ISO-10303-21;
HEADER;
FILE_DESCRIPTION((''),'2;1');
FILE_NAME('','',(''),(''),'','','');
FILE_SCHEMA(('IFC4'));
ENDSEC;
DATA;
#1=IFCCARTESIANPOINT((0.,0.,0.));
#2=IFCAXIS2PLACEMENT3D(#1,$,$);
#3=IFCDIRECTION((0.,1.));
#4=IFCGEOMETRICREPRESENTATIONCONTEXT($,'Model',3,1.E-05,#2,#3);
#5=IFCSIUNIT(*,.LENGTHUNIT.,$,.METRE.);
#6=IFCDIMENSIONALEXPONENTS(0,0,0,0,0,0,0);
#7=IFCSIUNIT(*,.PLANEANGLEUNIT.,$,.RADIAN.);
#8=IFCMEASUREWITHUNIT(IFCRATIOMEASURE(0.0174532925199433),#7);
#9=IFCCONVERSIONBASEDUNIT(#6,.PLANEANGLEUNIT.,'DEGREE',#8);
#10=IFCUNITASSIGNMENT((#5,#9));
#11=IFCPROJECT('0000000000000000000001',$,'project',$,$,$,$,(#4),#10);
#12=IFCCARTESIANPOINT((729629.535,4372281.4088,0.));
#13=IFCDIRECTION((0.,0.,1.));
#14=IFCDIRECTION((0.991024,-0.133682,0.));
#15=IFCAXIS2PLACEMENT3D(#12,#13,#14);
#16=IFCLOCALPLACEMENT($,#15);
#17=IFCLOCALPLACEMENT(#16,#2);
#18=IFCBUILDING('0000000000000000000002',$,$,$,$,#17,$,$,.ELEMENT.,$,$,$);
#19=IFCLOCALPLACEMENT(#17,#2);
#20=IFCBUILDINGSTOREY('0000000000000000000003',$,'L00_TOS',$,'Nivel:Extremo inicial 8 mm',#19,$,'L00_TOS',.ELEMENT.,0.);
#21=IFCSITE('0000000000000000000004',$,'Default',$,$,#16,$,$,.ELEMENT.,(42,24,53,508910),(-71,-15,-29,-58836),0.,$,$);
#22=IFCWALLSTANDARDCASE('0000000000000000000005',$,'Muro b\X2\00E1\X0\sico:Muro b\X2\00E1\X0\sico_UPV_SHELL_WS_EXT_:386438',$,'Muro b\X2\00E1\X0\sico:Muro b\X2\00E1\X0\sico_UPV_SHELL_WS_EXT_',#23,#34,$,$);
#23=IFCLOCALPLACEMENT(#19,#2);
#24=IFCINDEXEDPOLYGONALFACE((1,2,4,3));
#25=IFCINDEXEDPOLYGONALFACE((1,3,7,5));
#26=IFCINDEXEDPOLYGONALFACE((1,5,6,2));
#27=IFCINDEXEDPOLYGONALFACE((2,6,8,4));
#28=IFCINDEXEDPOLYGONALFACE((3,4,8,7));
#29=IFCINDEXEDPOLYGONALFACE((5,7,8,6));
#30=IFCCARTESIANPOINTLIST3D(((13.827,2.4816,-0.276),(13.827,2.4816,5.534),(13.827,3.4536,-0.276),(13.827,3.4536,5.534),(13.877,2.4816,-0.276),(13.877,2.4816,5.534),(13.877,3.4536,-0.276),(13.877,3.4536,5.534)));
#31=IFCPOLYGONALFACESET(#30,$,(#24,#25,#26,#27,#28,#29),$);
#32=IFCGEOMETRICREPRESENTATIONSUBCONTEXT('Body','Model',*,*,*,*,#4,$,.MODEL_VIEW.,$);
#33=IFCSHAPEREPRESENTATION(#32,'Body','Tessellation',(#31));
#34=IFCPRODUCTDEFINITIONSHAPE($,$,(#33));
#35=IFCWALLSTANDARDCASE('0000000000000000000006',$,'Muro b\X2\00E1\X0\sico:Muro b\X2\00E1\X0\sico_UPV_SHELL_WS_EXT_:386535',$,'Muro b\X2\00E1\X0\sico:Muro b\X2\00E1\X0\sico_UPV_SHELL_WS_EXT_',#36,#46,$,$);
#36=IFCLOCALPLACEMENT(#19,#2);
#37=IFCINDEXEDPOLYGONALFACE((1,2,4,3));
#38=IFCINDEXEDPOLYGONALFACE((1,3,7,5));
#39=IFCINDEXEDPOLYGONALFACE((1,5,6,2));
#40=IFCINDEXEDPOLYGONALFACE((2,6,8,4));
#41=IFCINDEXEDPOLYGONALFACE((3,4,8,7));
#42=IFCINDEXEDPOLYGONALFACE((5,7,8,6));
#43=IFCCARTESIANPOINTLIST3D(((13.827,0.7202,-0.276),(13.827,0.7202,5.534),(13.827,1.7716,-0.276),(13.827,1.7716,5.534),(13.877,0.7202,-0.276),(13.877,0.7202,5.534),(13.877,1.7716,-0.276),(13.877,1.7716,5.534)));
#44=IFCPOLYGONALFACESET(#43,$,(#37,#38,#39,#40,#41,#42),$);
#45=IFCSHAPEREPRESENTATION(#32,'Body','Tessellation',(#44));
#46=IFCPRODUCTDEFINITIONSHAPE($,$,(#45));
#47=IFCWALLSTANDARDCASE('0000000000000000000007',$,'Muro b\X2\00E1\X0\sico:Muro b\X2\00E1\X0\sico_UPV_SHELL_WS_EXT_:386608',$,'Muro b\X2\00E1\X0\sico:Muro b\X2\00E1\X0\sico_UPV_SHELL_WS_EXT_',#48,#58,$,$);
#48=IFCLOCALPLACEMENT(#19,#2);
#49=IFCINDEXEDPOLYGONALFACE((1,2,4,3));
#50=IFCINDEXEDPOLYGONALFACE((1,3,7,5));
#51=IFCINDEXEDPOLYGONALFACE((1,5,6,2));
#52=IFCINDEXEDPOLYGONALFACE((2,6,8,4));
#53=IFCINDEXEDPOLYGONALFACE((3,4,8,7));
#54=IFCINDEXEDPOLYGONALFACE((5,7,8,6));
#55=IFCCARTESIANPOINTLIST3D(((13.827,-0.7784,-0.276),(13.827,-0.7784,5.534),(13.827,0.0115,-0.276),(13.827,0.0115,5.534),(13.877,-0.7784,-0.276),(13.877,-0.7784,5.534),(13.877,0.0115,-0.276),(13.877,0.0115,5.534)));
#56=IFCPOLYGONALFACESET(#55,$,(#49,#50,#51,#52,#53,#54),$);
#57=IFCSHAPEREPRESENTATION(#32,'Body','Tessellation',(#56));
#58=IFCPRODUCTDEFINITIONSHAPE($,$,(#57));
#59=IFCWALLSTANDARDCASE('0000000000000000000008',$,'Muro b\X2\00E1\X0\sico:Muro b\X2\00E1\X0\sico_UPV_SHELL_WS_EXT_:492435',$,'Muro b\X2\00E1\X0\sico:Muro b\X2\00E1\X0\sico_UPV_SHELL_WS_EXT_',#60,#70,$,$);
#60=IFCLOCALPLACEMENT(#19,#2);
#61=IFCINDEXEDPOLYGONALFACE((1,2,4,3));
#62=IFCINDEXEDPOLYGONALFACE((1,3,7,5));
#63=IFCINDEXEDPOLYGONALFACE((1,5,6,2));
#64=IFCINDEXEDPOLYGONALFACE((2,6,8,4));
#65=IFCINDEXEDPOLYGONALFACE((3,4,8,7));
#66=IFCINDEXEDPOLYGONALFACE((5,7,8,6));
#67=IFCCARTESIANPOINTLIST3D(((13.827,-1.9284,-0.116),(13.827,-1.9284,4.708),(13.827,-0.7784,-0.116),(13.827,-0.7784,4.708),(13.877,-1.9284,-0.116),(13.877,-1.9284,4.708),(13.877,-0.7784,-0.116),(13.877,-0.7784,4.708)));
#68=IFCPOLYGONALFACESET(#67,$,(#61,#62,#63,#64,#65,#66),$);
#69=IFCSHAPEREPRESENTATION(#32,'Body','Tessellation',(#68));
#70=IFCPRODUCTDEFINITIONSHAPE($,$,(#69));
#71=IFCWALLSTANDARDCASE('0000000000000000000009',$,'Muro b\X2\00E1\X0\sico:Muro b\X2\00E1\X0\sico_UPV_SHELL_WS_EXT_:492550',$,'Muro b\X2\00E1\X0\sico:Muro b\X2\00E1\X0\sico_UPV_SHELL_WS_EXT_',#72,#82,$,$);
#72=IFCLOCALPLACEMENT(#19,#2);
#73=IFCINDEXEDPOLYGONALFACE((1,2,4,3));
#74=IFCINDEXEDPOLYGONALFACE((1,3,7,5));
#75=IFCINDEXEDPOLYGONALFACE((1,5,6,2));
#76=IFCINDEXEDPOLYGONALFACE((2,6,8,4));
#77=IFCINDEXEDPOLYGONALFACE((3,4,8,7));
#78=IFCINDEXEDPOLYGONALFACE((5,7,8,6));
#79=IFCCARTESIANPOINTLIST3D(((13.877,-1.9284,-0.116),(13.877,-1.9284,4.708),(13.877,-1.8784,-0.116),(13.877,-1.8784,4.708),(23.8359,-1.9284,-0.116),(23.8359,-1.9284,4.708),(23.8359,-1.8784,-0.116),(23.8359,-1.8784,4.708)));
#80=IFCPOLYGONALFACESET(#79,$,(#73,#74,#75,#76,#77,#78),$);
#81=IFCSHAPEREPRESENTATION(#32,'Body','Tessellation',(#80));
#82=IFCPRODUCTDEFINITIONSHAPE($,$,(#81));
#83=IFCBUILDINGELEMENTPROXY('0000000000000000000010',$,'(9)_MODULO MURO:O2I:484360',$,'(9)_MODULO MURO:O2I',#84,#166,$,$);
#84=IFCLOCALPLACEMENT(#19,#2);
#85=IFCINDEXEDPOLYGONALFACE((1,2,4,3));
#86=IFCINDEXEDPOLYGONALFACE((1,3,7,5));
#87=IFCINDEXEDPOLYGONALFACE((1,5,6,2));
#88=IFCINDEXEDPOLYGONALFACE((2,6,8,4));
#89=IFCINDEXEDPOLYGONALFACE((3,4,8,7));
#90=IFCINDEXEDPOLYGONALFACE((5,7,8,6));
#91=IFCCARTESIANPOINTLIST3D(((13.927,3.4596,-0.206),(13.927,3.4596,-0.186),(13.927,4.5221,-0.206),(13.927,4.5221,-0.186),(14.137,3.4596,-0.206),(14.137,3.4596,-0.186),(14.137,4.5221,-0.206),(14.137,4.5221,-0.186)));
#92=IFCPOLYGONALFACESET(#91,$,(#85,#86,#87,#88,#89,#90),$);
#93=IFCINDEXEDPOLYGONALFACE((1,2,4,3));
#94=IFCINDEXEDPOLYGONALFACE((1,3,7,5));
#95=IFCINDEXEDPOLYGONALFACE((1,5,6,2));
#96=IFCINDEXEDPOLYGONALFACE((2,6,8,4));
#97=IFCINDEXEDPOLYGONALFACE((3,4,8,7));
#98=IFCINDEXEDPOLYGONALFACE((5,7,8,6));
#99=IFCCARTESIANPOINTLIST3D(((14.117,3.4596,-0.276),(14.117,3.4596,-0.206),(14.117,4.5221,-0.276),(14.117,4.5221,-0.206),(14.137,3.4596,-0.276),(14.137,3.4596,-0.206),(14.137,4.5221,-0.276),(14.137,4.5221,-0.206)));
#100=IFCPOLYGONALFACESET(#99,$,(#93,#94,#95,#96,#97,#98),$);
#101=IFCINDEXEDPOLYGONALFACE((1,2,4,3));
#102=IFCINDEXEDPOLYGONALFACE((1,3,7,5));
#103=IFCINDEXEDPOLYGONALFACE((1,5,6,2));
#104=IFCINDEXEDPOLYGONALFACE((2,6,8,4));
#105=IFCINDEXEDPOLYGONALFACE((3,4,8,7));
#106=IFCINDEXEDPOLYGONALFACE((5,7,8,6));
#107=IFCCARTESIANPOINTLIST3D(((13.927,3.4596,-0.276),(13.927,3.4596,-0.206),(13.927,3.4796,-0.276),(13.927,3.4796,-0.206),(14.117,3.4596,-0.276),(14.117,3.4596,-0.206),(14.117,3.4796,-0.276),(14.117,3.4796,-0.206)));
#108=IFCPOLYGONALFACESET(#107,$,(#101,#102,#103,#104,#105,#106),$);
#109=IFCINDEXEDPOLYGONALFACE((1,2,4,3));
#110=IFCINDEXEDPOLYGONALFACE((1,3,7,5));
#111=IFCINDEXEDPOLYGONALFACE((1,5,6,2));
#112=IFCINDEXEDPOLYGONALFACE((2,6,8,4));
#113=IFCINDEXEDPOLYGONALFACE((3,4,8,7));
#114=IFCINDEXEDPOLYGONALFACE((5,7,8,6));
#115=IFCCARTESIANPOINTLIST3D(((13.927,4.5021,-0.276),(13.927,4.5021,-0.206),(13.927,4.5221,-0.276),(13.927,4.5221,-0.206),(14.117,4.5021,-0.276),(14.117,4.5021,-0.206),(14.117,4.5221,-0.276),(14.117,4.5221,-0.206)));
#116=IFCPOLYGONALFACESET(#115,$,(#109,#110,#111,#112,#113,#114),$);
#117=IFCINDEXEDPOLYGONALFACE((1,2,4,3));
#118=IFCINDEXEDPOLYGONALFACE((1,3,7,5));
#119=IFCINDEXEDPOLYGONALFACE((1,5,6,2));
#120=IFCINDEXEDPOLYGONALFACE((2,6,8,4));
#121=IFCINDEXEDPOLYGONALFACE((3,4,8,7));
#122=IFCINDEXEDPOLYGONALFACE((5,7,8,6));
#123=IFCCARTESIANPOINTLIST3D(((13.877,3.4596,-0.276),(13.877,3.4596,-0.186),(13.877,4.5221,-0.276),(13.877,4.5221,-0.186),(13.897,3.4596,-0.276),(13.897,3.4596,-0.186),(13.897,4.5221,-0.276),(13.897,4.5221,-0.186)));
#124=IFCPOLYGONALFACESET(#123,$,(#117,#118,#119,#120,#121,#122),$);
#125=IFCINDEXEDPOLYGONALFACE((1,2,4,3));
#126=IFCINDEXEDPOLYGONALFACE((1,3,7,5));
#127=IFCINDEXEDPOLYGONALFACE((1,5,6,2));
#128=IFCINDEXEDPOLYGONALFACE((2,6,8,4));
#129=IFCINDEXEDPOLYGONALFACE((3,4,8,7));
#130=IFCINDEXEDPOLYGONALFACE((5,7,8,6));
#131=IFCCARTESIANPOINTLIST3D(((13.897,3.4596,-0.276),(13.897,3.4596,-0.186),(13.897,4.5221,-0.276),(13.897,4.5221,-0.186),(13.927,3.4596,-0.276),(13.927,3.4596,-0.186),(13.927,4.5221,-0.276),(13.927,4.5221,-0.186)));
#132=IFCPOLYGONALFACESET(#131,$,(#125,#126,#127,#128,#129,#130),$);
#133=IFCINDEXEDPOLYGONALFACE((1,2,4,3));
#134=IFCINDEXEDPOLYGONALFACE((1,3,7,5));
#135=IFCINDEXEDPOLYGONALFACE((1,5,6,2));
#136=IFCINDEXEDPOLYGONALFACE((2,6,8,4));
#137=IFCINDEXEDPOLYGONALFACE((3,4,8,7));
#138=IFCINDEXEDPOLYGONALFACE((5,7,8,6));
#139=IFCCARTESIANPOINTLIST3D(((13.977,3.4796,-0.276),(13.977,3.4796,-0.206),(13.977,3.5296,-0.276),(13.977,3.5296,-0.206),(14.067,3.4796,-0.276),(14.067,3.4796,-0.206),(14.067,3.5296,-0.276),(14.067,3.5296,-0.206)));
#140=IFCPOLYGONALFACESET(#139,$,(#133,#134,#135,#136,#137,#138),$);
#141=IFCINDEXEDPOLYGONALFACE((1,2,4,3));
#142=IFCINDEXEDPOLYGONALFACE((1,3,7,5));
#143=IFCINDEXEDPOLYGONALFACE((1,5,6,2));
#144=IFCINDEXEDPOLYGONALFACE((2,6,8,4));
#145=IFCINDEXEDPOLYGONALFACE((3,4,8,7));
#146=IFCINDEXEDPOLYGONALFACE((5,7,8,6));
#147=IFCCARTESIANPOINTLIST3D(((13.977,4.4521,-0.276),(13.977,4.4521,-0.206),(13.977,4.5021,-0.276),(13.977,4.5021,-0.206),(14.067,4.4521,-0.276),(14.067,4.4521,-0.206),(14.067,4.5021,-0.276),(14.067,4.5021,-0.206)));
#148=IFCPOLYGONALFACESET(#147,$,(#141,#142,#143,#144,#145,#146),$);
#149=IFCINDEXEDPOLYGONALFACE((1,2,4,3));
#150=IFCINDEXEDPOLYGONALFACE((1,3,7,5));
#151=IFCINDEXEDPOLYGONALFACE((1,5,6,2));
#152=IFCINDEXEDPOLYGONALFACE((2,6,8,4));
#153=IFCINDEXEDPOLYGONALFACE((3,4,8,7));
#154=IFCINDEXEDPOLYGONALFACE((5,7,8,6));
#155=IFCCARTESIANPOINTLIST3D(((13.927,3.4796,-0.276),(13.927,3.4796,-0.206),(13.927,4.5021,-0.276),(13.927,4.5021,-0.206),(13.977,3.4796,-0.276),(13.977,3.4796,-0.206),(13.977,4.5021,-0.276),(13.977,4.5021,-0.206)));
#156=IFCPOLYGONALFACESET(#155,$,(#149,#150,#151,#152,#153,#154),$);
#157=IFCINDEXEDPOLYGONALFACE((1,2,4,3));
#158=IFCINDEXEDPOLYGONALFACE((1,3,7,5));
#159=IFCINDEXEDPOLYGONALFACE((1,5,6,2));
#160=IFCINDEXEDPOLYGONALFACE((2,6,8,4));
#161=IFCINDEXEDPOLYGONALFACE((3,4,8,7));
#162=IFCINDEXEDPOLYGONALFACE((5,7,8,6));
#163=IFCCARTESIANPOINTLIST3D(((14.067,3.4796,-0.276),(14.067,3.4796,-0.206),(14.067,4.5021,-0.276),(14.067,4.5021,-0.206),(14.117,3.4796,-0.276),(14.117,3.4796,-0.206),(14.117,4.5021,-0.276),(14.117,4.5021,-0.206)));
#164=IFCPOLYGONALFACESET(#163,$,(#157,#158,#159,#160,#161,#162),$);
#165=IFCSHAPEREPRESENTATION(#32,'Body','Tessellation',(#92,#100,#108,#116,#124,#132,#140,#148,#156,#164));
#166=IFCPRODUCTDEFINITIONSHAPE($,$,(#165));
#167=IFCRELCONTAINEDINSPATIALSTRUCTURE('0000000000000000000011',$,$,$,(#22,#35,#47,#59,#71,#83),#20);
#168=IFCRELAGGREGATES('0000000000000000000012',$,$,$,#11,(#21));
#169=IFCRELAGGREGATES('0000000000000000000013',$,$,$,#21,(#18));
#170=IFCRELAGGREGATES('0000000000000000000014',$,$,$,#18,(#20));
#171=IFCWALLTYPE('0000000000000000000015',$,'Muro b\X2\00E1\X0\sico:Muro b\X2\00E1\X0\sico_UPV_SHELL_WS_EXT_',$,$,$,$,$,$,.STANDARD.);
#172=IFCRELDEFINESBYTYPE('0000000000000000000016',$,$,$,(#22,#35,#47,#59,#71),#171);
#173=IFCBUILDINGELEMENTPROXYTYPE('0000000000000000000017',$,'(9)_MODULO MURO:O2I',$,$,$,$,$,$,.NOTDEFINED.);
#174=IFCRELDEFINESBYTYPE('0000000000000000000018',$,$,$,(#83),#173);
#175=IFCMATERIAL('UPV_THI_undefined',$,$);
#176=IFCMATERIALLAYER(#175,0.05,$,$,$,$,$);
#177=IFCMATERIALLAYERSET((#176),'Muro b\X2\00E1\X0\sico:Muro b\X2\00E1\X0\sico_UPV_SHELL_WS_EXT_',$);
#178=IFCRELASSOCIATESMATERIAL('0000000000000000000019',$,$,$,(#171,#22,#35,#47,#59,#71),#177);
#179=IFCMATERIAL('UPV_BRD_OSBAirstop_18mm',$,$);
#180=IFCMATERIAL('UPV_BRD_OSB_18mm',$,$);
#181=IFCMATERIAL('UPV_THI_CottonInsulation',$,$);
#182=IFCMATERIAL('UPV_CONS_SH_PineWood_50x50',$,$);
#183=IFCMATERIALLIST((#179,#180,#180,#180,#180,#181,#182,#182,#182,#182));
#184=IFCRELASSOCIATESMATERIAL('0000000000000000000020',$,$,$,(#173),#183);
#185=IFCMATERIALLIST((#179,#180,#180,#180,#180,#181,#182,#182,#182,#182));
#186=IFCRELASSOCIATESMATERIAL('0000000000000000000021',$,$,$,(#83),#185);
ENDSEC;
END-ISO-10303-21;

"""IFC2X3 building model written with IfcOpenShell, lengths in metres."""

from ifc_helpers import new_model, entity, si_unit, converted_unit, direction, frame, frame_2d, origin, origin_2d_with_axis, place, context, subcontext, project, spatial, rectangle, extrude, source, transform, mapped, material, material_list, layer, layer_set, layer_usage, type_object, type_shapes, element, save


model = new_model("IFC2X3")

# Units and contexts
model_context = context("Model", 3, precision=1e-05, world=origin(), true_north=direction((0.0, 1.0)))
body_context = subcontext(model_context, "Body", "Model", "MODEL_VIEW")
ifc_project = project(units=[si_unit("LENGTHUNIT", "METRE"), converted_unit("PLANEANGLEUNIT", "DEGREE", entity("IfcRatioMeasure", 0.0174532925199433), si_unit("PLANEANGLEUNIT", "RADIAN"), dimensions=[0, 0, 0, 0, 0, 0, 0])], contexts=[model_context])

# Site, building, storey
site_placement = place(None, frame((729629.535, 4372281.4088, 0.0), z_axis=(0.0, 0.0, 1.0), x_axis=(0.991024, -0.133682, 0.0)))
site = spatial("IfcSite", under=ifc_project, at=site_placement, Name="Default", CompositionType="ELEMENT", RefLatitude=(42, 24, 53, 508910), RefLongitude=(-71, -15, -29, -58836), RefElevation=0.0)
building_placement = place(site_placement, origin())
building = spatial("IfcBuilding", under=site, at=building_placement, CompositionType="ELEMENT")
storey_placement = place(building_placement, origin())
storey = spatial("IfcBuildingStorey", under=building, at=storey_placement, Name="L00_TOS", ObjectType="Nivel:Extremo inicial 8 mm", LongName="L00_TOS", CompositionType="ELEMENT", Elevation=0.0)

# Shared definitions
ifc_material_1 = material(Name="UPV_THI_undefined")

# Walls
ifc_layer_1 = layer(ifc_material_1, 0.05)
ifc_layer_set_1 = layer_set([ifc_layer_1], Name="Muro básico:Muro básico_UPV_SHELL_WS_EXT_")
ifc_layer_usage_1 = layer_usage(ifc_layer_set_1, "AXIS2", "NEGATIVE", 0.025)
wall_type_1 = type_object("IfcWallType", Name="Muro básico:Muro básico_UPV_SHELL_WS_EXT_", PredefinedType="STANDARD", material=ifc_layer_set_1)
wall_1_placement = place(storey_placement, frame((13.852, 3.4536, -0.276), z_axis=(0.0, 0.0, 1.0), x_axis=(0.0, -1.0, 0.0)))
element("IfcWallStandardCase", 1, at=wall_1_placement, inside=storey, type_object=wall_type_1, material=ifc_layer_usage_1, Name="Muro básico:Muro básico_UPV_SHELL_WS_EXT_:386438", ObjectType="Muro básico:Muro básico_UPV_SHELL_WS_EXT_", context=body_context, shape_type="SweptSolid", body=[
    extrude(rectangle(XDim=0.972, YDim=0.05, at=frame_2d((0.486, 0.0), x_axis=(-1.0, 0.0))), origin(), (0.0, 0.0, 1.0), 5.81),
])
ifc_layer_usage_2 = layer_usage(ifc_layer_set_1, "AXIS2", "NEGATIVE", 0.025)
wall_2_placement = place(storey_placement, frame((13.852, 1.7716, -0.276), z_axis=(0.0, 0.0, 1.0), x_axis=(0.0, -1.0, 0.0)))
element("IfcWallStandardCase", 2, at=wall_2_placement, inside=storey, type_object=wall_type_1, material=ifc_layer_usage_2, Name="Muro básico:Muro básico_UPV_SHELL_WS_EXT_:386535", ObjectType="Muro básico:Muro básico_UPV_SHELL_WS_EXT_", context=body_context, shape_type="SweptSolid", body=[
    extrude(rectangle(XDim=1.0514, YDim=0.05, at=frame_2d((0.5257, 0.0), x_axis=(-1.0, 0.0))), origin(), (0.0, 0.0, 1.0), 5.81),
])
ifc_layer_usage_3 = layer_usage(ifc_layer_set_1, "AXIS2", "NEGATIVE", 0.025)
wall_3_placement = place(storey_placement, frame((13.852, 0.0115, -0.276), z_axis=(0.0, 0.0, 1.0), x_axis=(0.0, -1.0, 0.0)))
element("IfcWallStandardCase", 3, at=wall_3_placement, inside=storey, type_object=wall_type_1, material=ifc_layer_usage_3, Name="Muro básico:Muro básico_UPV_SHELL_WS_EXT_:386608", ObjectType="Muro básico:Muro básico_UPV_SHELL_WS_EXT_", context=body_context, shape_type="SweptSolid", body=[
    extrude(rectangle(XDim=0.7899, YDim=0.05, at=frame_2d((0.395, 0.0), x_axis=(-1.0, 0.0))), origin(), (0.0, 0.0, 1.0), 5.81),
])
ifc_layer_usage_4 = layer_usage(ifc_layer_set_1, "AXIS2", "NEGATIVE", 0.025)
wall_4_placement = place(storey_placement, frame((13.852, -0.7784, -0.116), z_axis=(0.0, 0.0, 1.0), x_axis=(0.0, -1.0, 0.0)))
element("IfcWallStandardCase", 4, at=wall_4_placement, inside=storey, type_object=wall_type_1, material=ifc_layer_usage_4, Name="Muro básico:Muro básico_UPV_SHELL_WS_EXT_:492435", ObjectType="Muro básico:Muro básico_UPV_SHELL_WS_EXT_", context=body_context, shape_type="SweptSolid", body=[
    extrude(rectangle(XDim=1.15, YDim=0.05, at=frame_2d((0.575, 0.0), x_axis=(-1.0, 0.0))), origin(), (0.0, 0.0, 1.0), 4.824),
])
ifc_layer_usage_5 = layer_usage(ifc_layer_set_1, "AXIS2", "NEGATIVE", 0.025)
wall_5_placement = place(storey_placement, frame((13.877, -1.9034, -0.116)))
element("IfcWallStandardCase", 5, at=wall_5_placement, inside=storey, type_object=wall_type_1, material=ifc_layer_usage_5, Name="Muro básico:Muro básico_UPV_SHELL_WS_EXT_:492550", ObjectType="Muro básico:Muro básico_UPV_SHELL_WS_EXT_", context=body_context, shape_type="SweptSolid", body=[
    extrude(rectangle(XDim=9.959, YDim=0.05, at=frame_2d((4.9795, 0.0), x_axis=(-1.0, 0.0))), origin(), (0.0, 0.0, 1.0), 4.824),
])

# Building element proxy
ifc_material_2 = material(Name="UPV_BRD_OSBAirstop_18mm")
ifc_material_3 = material(Name="UPV_BRD_OSB_18mm")
ifc_material_4 = material(Name="UPV_THI_CottonInsulation")
ifc_material_5 = material(Name="UPV_CONS_SH_PineWood_50x50")
ifc_material_list_1 = material_list([ifc_material_2, ifc_material_3, ifc_material_3, ifc_material_3, ifc_material_3, ifc_material_4, ifc_material_5, ifc_material_5, ifc_material_5, ifc_material_5])
ifc_material_list_2 = material_list([ifc_material_2, ifc_material_3, ifc_material_3, ifc_material_3, ifc_material_3, ifc_material_4, ifc_material_5, ifc_material_5, ifc_material_5, ifc_material_5])
building_element_proxy_type_1 = type_object("IfcBuildingElementProxyType", Name="(9)_MODULO MURO:O2I", PredefinedType="NOTDEFINED", material=ifc_material_list_2)
shared_shape_1 = source(origin(), body_context, "Body", "SweptSolid", [
    extrude(rectangle(XDim=1.0625, YDim=0.21, at=origin_2d_with_axis()), frame((0.0, -0.01, 0.07)), (0.0, 0.0, 1.0), 0.02),
    extrude(rectangle(XDim=1.0625, YDim=0.02, at=origin_2d_with_axis()), frame((0.0, -0.105, 0.0), z_axis=(0.0, 0.0, 1.0), x_axis=(-1.0, 0.0, 0.0)), (0.0, 0.0, 1.0), 0.07),
    extrude(rectangle(XDim=0.19, YDim=0.02, at=frame_2d((0.0, 0.0), x_axis=(1.0, 0.0))), frame((-0.5213, 0.0, 0.0), z_axis=(0.0, 0.0, 1.0), x_axis=(0.0, -1.0, 0.0)), (0.0, 0.0, 1.0), 0.07),
    extrude(rectangle(XDim=0.19, YDim=0.02, at=frame_2d((0.0, 0.0), x_axis=(1.0, 0.0))), frame((0.5213, 0.0, 0.0), z_axis=(0.0, 0.0, 1.0), x_axis=(0.0, -1.0, 0.0)), (0.0, 0.0, 1.0), 0.07),
    extrude(rectangle(XDim=1.0625, YDim=0.02, at=origin_2d_with_axis()), frame((0.0, 0.135, 0.0), z_axis=(0.0, 0.0, 1.0), x_axis=(-1.0, 0.0, 0.0)), (0.0, 0.0, 1.0), 0.09),
    extrude(rectangle(XDim=1.0625, YDim=0.03, at=origin_2d_with_axis()), frame((0.0, 0.11, 0.0)), (0.0, 0.0, 1.0), 0.09),
    extrude(rectangle(XDim=0.09, YDim=0.05, at=origin_2d_with_axis()), frame((-0.4863, 0.0, 0.0), z_axis=(0.0, 0.0, 1.0), x_axis=(0.0, -1.0, 0.0)), (0.0, 0.0, 1.0), 0.07),
    extrude(rectangle(XDim=0.09, YDim=0.05, at=origin_2d_with_axis()), frame((0.4863, 0.0, 0.0), z_axis=(0.0, 0.0, 1.0), x_axis=(0.0, -1.0, 0.0)), (0.0, 0.0, 1.0), 0.07),
    extrude(rectangle(XDim=0.05, YDim=1.0225, at=origin_2d_with_axis()), frame((0.0, 0.07, 0.0), z_axis=(0.0, 0.0, 1.0), x_axis=(0.0, -1.0, 0.0)), (0.0, 0.0, 1.0), 0.07),
    extrude(rectangle(XDim=0.05, YDim=1.0225, at=origin_2d_with_axis()), frame((0.0, -0.07, 0.0), z_axis=(0.0, 0.0, 1.0), x_axis=(0.0, -1.0, 0.0)), (0.0, 0.0, 1.0), 0.07),
])
type_shapes(building_element_proxy_type_1, [shared_shape_1])
proxy_1_placement = place(storey_placement, frame((14.022, 3.9909, -0.276), z_axis=(0.0, 0.0, 1.0), x_axis=(0.0, 1.0, 0.0)))
element("IfcBuildingElementProxy", 6, at=proxy_1_placement, inside=storey, type_object=building_element_proxy_type_1, material=ifc_material_list_1, Name="(9)_MODULO MURO:O2I:484360", ObjectType="(9)_MODULO MURO:O2I", context=body_context, shape_type="MappedRepresentation", body=[
    mapped(shared_shape_1, transform((0.0, 0.0, 0.0), scale=1.0)),
])

save(model, "model.ifc")
